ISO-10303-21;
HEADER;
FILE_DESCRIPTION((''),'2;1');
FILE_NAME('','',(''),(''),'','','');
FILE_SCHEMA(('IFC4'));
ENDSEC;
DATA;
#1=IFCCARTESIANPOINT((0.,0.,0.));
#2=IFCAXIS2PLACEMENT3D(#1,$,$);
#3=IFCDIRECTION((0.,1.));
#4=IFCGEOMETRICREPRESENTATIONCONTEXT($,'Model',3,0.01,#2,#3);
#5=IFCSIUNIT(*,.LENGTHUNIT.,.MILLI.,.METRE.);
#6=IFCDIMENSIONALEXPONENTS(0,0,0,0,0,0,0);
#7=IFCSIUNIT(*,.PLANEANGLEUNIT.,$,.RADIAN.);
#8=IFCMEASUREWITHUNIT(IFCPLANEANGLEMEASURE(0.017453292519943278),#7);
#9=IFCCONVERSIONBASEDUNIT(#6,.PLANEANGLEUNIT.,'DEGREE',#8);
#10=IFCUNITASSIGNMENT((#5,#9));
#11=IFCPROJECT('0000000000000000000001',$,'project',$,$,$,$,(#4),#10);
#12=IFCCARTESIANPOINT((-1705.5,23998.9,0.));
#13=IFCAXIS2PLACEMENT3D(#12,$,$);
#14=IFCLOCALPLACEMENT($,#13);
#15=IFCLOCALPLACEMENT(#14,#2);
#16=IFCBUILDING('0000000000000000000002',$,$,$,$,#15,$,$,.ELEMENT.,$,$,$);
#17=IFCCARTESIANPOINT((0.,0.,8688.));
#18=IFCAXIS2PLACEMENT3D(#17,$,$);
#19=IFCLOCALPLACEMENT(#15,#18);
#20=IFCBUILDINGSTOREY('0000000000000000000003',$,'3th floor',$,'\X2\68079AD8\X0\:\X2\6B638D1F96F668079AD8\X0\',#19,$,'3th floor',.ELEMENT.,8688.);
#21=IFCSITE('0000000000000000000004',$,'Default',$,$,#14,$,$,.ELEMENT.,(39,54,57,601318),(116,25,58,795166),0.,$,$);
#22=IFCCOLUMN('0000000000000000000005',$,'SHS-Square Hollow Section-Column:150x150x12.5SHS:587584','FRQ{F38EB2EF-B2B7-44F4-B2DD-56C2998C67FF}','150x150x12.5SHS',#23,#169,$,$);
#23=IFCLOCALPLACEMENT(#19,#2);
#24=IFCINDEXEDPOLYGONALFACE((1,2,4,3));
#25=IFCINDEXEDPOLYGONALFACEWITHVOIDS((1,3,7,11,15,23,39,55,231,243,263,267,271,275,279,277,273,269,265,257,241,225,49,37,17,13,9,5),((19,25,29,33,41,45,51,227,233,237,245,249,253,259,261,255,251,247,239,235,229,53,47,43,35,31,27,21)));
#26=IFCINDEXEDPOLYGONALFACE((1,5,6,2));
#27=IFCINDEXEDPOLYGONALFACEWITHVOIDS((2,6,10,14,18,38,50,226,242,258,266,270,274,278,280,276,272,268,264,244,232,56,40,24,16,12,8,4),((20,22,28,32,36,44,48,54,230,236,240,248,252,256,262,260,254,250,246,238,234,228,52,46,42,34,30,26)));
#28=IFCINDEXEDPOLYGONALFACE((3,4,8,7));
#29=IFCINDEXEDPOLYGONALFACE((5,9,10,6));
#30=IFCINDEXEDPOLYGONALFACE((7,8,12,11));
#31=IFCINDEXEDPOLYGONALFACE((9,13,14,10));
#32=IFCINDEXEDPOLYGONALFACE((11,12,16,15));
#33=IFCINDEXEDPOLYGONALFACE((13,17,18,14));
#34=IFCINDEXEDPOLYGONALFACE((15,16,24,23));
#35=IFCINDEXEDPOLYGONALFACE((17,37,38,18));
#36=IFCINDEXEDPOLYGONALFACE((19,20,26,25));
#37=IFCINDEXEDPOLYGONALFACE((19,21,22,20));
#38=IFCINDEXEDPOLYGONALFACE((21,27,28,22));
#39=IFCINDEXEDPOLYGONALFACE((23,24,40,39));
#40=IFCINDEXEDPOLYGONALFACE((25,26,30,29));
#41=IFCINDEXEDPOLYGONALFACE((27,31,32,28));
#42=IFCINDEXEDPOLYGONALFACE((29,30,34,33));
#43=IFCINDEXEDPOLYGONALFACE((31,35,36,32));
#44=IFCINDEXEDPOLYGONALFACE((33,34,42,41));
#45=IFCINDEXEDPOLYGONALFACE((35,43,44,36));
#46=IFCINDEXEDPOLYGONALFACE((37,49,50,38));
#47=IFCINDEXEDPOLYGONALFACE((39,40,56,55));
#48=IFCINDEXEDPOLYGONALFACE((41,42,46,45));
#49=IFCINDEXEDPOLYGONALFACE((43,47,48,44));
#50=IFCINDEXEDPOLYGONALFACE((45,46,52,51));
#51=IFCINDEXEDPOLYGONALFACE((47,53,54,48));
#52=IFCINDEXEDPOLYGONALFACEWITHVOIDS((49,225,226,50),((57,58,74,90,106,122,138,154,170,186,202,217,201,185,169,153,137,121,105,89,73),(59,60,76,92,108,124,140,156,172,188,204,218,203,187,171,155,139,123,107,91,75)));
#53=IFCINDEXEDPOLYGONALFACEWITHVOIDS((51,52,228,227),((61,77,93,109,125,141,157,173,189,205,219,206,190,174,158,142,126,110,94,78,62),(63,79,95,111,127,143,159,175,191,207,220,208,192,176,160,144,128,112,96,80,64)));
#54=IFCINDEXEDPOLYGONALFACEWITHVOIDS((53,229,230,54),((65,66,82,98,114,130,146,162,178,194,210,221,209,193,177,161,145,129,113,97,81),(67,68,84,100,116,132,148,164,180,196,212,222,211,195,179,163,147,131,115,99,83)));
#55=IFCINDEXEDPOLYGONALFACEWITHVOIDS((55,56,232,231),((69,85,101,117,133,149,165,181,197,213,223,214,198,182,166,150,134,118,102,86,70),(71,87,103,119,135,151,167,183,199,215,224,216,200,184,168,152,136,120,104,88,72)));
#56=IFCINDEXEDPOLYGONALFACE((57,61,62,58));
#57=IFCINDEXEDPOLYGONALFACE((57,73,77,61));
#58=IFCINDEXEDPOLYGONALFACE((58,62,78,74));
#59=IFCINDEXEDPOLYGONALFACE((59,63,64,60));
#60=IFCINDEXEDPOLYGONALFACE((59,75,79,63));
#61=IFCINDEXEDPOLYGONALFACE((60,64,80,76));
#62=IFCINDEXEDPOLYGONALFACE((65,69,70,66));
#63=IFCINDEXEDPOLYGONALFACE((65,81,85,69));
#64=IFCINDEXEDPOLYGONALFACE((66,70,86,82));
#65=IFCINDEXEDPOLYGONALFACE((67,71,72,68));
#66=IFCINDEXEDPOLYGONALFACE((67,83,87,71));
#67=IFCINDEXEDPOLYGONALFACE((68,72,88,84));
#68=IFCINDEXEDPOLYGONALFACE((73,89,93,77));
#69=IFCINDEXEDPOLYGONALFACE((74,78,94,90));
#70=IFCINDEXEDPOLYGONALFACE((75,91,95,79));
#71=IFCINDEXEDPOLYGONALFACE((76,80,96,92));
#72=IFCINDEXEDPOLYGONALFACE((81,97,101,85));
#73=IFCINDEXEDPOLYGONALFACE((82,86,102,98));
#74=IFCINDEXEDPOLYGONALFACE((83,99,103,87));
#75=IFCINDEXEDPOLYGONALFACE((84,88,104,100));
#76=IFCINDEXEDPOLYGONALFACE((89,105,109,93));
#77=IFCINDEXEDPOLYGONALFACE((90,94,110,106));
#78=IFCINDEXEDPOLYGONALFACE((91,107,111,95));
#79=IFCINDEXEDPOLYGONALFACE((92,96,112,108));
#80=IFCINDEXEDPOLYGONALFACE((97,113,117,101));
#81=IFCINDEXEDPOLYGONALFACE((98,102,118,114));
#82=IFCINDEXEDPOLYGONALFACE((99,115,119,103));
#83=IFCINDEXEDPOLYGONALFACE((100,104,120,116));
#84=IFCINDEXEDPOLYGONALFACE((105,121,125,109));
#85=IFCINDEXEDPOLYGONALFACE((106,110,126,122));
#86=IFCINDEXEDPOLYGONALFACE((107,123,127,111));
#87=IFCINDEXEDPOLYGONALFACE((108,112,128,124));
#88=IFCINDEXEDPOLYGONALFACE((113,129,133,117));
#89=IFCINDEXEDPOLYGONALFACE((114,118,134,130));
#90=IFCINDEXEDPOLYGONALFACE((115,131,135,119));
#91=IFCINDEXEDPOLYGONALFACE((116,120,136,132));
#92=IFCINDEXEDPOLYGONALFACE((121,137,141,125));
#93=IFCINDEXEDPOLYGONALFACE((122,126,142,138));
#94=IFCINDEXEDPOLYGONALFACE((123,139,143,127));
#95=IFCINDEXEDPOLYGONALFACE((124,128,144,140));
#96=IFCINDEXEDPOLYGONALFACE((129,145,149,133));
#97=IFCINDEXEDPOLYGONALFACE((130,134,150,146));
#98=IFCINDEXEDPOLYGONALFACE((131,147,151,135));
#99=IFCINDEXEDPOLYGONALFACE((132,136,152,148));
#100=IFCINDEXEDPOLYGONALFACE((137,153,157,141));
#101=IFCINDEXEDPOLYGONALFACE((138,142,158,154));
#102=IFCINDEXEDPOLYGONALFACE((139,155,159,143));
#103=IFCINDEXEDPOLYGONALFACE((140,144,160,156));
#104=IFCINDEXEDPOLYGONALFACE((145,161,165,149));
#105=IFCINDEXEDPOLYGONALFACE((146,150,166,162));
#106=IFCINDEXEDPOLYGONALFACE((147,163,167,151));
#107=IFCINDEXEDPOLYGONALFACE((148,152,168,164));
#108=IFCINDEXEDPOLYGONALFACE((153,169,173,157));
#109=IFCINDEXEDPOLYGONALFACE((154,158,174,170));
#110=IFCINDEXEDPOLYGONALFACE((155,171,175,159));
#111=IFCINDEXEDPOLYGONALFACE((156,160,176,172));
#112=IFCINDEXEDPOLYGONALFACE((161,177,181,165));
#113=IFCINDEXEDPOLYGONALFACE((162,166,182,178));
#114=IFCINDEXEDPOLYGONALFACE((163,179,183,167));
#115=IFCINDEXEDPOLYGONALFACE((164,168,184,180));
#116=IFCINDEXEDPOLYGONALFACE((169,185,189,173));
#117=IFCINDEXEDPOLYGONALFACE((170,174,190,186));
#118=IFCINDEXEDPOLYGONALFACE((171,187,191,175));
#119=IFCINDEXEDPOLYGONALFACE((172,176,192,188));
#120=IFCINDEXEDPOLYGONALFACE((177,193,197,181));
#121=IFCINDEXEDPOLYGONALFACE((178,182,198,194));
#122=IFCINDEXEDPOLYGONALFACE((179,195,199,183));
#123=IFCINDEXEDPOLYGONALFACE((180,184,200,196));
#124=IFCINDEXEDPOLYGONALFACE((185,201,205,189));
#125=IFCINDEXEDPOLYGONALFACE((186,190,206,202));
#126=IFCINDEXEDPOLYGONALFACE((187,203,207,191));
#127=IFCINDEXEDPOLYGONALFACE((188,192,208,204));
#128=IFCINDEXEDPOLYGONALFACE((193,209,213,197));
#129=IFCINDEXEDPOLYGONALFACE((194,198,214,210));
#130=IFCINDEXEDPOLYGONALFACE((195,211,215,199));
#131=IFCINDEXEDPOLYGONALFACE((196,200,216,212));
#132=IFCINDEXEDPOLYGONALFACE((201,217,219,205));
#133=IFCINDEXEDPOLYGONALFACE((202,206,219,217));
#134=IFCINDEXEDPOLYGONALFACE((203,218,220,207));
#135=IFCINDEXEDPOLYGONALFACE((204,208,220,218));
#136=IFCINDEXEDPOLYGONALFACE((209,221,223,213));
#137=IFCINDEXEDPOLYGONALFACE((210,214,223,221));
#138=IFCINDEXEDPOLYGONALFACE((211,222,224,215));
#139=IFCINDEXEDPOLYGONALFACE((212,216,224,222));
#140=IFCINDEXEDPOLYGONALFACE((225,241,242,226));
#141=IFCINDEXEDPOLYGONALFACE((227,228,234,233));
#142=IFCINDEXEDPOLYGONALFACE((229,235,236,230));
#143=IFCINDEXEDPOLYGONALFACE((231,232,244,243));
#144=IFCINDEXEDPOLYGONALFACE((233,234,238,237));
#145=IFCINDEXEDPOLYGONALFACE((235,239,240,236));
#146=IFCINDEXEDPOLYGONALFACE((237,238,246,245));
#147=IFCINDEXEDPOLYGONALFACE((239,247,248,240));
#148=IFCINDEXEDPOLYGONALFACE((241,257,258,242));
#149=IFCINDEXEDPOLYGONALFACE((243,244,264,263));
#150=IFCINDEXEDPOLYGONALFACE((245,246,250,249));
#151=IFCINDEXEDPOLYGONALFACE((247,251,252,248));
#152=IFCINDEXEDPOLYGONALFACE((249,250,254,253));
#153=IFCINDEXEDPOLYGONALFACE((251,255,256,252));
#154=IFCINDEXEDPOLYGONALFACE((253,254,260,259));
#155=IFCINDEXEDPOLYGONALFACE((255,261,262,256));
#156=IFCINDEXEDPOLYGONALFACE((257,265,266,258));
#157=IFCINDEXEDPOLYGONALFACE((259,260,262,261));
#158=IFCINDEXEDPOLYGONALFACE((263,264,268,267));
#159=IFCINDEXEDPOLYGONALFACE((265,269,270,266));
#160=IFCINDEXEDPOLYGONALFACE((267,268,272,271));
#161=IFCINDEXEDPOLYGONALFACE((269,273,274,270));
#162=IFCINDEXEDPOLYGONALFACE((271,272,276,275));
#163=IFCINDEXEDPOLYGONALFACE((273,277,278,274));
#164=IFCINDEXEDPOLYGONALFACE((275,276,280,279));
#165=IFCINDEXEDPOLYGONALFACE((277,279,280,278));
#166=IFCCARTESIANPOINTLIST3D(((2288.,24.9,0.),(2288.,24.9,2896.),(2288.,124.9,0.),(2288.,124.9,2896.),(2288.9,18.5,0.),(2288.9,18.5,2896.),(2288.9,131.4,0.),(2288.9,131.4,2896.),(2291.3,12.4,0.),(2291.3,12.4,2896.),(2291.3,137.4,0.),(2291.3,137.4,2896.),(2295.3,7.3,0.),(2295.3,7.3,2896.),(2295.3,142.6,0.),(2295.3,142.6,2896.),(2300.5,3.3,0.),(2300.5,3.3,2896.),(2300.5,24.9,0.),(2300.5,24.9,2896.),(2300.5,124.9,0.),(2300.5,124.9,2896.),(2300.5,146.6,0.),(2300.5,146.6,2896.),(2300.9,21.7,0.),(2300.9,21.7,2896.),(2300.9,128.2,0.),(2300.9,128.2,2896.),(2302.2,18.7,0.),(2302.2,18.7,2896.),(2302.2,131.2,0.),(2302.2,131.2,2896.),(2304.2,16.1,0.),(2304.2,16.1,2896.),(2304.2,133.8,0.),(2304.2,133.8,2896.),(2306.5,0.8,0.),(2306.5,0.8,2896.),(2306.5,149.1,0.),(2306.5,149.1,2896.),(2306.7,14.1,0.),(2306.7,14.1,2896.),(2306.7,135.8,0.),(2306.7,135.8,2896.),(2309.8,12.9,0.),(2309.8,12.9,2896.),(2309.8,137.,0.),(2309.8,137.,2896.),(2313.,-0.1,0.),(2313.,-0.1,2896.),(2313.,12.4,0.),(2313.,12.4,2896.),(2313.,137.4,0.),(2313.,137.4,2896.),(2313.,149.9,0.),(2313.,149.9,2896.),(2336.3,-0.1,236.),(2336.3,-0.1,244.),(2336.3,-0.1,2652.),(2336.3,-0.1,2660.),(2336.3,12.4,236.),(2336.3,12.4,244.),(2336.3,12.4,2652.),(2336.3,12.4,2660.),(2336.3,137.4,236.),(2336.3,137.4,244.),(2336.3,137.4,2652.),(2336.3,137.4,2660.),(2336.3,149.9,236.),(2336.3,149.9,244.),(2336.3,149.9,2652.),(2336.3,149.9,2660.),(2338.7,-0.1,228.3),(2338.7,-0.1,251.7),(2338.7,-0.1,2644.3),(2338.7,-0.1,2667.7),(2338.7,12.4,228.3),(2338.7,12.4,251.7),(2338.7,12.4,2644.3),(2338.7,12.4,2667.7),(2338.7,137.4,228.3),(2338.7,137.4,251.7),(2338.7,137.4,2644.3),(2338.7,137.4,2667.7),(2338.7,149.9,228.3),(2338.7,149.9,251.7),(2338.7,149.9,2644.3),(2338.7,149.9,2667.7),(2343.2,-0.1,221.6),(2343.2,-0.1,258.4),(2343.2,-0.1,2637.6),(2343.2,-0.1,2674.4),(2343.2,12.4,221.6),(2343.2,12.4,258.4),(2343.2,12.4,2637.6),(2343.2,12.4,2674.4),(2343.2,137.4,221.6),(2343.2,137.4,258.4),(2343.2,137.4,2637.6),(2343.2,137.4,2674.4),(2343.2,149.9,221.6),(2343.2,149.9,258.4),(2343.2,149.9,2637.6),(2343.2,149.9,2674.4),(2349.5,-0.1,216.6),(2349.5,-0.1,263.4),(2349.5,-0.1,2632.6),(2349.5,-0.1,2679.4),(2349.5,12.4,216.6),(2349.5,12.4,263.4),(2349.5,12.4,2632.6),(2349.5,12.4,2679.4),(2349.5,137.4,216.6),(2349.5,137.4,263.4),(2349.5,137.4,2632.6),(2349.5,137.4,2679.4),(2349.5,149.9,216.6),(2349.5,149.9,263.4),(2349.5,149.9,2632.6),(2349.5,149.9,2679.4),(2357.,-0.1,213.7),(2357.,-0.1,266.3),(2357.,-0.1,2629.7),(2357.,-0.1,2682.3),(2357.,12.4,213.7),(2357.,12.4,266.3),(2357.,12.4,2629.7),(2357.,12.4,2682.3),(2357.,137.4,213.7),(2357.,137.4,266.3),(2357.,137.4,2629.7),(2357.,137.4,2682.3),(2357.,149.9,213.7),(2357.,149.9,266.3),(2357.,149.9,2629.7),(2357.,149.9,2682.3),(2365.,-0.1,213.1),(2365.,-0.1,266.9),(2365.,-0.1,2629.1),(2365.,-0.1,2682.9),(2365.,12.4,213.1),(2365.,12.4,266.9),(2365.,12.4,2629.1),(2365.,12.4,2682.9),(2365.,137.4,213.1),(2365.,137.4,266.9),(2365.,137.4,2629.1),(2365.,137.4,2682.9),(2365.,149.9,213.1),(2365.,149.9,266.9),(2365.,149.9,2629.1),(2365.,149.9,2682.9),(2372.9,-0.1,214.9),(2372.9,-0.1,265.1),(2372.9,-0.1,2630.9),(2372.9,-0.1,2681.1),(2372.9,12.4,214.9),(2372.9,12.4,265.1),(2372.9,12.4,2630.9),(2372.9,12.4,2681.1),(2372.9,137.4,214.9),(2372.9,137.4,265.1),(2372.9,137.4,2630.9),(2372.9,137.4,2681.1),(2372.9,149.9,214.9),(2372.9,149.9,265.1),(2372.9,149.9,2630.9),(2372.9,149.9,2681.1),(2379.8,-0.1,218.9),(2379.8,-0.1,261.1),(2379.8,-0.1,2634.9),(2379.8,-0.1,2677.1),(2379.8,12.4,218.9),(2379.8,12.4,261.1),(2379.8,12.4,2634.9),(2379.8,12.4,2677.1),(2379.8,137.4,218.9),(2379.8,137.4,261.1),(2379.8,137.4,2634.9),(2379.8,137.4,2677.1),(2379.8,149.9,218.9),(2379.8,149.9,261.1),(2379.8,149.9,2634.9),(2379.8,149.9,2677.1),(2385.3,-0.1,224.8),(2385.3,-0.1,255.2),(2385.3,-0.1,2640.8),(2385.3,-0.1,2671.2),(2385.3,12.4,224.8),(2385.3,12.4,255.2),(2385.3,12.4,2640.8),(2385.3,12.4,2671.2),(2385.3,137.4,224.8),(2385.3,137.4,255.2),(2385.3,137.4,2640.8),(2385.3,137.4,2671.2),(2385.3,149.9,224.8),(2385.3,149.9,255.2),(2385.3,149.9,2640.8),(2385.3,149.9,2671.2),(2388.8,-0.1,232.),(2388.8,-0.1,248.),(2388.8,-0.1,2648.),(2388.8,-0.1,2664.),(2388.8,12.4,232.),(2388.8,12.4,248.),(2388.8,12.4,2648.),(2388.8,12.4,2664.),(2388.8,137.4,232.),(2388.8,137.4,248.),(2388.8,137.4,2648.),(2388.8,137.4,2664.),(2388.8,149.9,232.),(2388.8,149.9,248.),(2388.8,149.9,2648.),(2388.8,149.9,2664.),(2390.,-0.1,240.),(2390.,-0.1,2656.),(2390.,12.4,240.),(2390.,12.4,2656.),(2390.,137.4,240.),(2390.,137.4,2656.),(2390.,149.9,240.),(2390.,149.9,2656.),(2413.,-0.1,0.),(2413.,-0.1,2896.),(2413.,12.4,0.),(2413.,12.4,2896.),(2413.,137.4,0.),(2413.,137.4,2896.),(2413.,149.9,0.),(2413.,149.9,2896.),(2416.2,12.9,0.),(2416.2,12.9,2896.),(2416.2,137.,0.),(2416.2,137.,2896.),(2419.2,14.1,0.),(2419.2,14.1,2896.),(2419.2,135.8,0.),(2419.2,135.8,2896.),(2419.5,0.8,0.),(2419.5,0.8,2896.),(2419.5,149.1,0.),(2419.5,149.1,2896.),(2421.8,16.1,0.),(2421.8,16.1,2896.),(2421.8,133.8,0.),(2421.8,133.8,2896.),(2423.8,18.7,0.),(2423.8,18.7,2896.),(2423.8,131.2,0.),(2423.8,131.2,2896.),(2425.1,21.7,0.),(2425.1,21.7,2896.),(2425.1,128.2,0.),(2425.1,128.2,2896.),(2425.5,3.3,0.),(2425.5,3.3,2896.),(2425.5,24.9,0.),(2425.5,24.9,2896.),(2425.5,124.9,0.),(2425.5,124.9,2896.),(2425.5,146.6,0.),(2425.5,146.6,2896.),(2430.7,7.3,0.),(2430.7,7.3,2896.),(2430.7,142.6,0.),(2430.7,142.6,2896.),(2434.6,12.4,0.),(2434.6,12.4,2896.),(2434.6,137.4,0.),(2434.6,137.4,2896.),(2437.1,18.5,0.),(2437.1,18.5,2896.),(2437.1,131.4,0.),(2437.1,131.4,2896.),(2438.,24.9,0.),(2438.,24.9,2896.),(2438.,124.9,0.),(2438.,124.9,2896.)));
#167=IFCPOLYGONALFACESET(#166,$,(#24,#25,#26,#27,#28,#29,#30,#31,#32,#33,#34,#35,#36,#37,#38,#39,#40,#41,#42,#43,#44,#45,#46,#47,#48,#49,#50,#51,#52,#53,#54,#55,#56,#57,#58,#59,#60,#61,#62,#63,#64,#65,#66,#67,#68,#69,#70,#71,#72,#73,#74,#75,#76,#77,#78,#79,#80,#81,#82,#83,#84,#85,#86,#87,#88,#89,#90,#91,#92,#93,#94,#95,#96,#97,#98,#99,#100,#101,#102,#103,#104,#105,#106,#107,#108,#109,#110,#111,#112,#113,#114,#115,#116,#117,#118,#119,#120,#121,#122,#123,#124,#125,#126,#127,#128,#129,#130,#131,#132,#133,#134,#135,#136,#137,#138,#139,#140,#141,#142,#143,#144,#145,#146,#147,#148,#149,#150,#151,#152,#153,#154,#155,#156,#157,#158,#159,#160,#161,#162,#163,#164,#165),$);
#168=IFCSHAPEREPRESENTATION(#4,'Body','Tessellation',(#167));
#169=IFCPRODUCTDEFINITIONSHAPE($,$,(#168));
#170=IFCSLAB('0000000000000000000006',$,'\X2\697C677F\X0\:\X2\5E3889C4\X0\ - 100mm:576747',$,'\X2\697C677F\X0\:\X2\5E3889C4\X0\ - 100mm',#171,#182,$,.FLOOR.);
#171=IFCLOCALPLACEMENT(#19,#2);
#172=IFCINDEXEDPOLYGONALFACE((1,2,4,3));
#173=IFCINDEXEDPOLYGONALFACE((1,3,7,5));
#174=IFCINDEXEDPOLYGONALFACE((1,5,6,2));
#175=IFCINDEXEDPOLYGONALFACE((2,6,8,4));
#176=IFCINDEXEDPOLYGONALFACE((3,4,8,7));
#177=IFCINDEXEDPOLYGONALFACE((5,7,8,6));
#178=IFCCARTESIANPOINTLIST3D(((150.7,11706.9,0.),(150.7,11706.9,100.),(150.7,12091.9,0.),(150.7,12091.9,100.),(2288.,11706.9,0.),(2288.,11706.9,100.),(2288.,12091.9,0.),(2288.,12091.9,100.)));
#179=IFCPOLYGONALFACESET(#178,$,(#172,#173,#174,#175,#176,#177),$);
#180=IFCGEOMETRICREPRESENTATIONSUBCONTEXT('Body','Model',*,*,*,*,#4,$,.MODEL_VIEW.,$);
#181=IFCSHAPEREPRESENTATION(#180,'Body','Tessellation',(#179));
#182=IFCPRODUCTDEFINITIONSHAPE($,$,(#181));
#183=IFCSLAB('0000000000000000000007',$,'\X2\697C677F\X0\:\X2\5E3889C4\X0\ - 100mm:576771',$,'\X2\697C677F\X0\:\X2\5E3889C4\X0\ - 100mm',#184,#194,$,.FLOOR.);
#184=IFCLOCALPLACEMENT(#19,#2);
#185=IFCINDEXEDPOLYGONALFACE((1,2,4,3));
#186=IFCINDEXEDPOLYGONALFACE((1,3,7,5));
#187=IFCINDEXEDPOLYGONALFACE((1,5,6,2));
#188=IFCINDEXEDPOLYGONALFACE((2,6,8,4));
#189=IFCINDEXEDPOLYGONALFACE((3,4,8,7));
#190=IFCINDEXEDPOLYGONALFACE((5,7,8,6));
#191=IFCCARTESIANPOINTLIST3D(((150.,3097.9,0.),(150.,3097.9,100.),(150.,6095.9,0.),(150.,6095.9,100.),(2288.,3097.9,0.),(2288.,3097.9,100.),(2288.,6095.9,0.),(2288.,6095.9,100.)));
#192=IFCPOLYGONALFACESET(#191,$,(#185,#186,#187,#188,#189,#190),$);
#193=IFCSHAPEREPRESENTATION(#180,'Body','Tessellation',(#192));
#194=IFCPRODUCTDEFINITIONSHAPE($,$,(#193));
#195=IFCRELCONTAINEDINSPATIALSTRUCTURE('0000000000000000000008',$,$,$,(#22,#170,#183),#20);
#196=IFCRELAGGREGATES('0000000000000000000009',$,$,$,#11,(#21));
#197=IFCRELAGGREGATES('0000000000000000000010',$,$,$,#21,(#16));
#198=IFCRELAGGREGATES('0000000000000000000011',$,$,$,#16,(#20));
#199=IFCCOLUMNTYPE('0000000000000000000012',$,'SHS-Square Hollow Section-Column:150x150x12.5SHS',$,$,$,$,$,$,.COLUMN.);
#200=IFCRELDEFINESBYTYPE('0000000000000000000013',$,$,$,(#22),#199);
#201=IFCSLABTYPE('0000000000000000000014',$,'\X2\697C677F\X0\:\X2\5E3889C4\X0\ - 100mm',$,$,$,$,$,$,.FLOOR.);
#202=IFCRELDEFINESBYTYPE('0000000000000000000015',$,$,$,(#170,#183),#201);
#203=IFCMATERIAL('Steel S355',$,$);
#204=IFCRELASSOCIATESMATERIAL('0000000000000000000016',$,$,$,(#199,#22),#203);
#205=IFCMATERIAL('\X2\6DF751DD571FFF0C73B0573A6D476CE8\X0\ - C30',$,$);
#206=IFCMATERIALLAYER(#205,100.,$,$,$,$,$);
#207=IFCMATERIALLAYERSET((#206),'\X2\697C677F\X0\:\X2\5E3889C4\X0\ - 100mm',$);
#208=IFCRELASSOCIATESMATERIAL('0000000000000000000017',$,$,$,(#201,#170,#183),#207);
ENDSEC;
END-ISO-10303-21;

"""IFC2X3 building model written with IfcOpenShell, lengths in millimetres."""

from ifc_helpers import new_model, entity, si_unit, converted_unit, direction, frame, frame_2d, origin, origin_2d, origin_2d_with_axis, place, context, subcontext, project, spatial, circle_curve, rectangle, hollow_rectangle, outline, extrude, material, layer, layer_set, layer_usage, type_object, element, save


model = new_model("IFC2X3")

# Units and contexts
model_context = context("Model", 3, precision=0.01, world=origin(), true_north=direction((0.0, 1.0)))
body_context = subcontext(model_context, "Body", "Model", "MODEL_VIEW")
ifc_project = project(units=[si_unit("LENGTHUNIT", "METRE", prefix="MILLI"), converted_unit("PLANEANGLEUNIT", "DEGREE", entity("IfcPlaneAngleMeasure", 0.017453292519943278), si_unit("PLANEANGLEUNIT", "RADIAN"), dimensions=[0, 0, 0, 0, 0, 0, 0])], contexts=[model_context])

# Site, building, storey
site_placement = place(None, frame((-1705.5, 23998.9, 0.0)))
site = spatial("IfcSite", under=ifc_project, at=site_placement, Name="Default", CompositionType="ELEMENT", RefLatitude=(39, 54, 57, 601318), RefLongitude=(116, 25, 58, 795166), RefElevation=0.0)
building_placement = place(site_placement, origin())
building = spatial("IfcBuilding", under=site, at=building_placement, CompositionType="ELEMENT")
storey_placement = place(building_placement, frame((0.0, 0.0, 8688.0)))
storey = spatial("IfcBuildingStorey", under=building, at=storey_placement, Name="3th floor", ObjectType="标高:正负零标高", LongName="3th floor", CompositionType="ELEMENT", Elevation=8688.0)

# Shared definitions
ifc_material_1 = material(Name="Steel S355")

# Column, openings
column_type_1 = type_object("IfcColumnType", Name="SHS-Square Hollow Section-Column:150x150x12.5SHS", PredefinedType="COLUMN", material=ifc_material_1)
column_1_placement = place(storey_placement, frame((2363.0, 74.9, 2896.0), z_axis=(0.0, 0.0, 1.0), x_axis=(0.0, -1.0, 0.0)))
column_1 = element("IfcColumn", 1, at=column_1_placement, inside=storey, type_object=column_type_1, material=ifc_material_1, Name="SHS-Square Hollow Section-Column:150x150x12.5SHS:587584", Description="FRQ{F38EB2EF-B2B7-44F4-B2DD-56C2998C67FF}", ObjectType="150x150x12.5SHS", context=model_context, shape_type="SweptSolid", body=[
    extrude(hollow_rectangle(XDim=150.0, YDim=150.0, WallThickness=12.5, InnerFilletRadius=12.5, OuterFilletRadius=25.0, at=origin_2d()), origin(), (0.0, 0.0, -1.0), 2896.0),
])
opening_1_placement = place(column_1_placement, frame((-175.1, 0.0, -2896.0), z_axis=(1.0, 0.0, 0.0), x_axis=(0.0, 1.0, 0.0)))
element("IfcOpeningElement", 2, at=opening_1_placement, cuts=column_1, ObjectType="Opening", context=model_context, shape_type="SweptSolid", body=[
    extrude(outline(circle_curve(frame_2d((0.0, 240.0), x_axis=(1.0, 0.0)), 27.0)), origin(), (0.0, 0.0, 1.0), 350.2),
])
opening_2_placement = place(column_1_placement, frame((-175.1, 0.0, 0.0), z_axis=(1.0, 0.0, 0.0), x_axis=(0.0, 1.0, 0.0)))
element("IfcOpeningElement", 3, at=opening_2_placement, cuts=column_1, ObjectType="Opening", context=model_context, shape_type="SweptSolid", body=[
    extrude(outline(circle_curve(frame_2d((0.0, -240.0), x_axis=(1.0, 0.0)), 27.0)), origin(), (0.0, 0.0, 1.0), 350.2),
])

# Slabs
ifc_material_2 = material(Name="混凝土，现场浇注 - C30")
ifc_layer_1 = layer(ifc_material_2, 100.0)
ifc_layer_set_1 = layer_set([ifc_layer_1], Name="楼板:常规 - 100mm")
ifc_layer_usage_1 = layer_usage(ifc_layer_set_1, "AXIS3", "POSITIVE", 0.0)
slab_type_1 = type_object("IfcSlabType", Name="楼板:常规 - 100mm", PredefinedType="FLOOR", material=ifc_layer_set_1)
slab_1_placement = place(storey_placement, origin())
element("IfcSlab", 4, at=slab_1_placement, inside=storey, type_object=slab_type_1, material=ifc_layer_usage_1, Name="楼板:常规 - 100mm:576747", ObjectType="楼板:常规 - 100mm", PredefinedType="FLOOR", context=body_context, shape_type="SweptSolid", body=[
    extrude(rectangle(XDim=385.0, YDim=2137.3, at=origin_2d_with_axis()), frame((1219.3, 11899.4, 100.0), z_axis=(0.0, 0.0, -1.0), x_axis=(0.0, 1.0, 0.0)), (0.0, 0.0, 1.0), 100.0),
])
ifc_layer_usage_2 = layer_usage(ifc_layer_set_1, "AXIS3", "POSITIVE", 0.0)
slab_2_placement = place(storey_placement, origin())
element("IfcSlab", 5, at=slab_2_placement, inside=storey, type_object=slab_type_1, material=ifc_layer_usage_2, Name="楼板:常规 - 100mm:576771", ObjectType="楼板:常规 - 100mm", PredefinedType="FLOOR", context=body_context, shape_type="SweptSolid", body=[
    extrude(rectangle(XDim=2998.0, YDim=2138.0, at=frame_2d((0.0, 0.0), x_axis=(1.0, 0.0))), frame((1219.0, 4596.9, 100.0), z_axis=(0.0, 0.0, -1.0), x_axis=(0.0, 1.0, 0.0)), (0.0, 0.0, 1.0), 100.0),
])

save(model, "model.ifc")
